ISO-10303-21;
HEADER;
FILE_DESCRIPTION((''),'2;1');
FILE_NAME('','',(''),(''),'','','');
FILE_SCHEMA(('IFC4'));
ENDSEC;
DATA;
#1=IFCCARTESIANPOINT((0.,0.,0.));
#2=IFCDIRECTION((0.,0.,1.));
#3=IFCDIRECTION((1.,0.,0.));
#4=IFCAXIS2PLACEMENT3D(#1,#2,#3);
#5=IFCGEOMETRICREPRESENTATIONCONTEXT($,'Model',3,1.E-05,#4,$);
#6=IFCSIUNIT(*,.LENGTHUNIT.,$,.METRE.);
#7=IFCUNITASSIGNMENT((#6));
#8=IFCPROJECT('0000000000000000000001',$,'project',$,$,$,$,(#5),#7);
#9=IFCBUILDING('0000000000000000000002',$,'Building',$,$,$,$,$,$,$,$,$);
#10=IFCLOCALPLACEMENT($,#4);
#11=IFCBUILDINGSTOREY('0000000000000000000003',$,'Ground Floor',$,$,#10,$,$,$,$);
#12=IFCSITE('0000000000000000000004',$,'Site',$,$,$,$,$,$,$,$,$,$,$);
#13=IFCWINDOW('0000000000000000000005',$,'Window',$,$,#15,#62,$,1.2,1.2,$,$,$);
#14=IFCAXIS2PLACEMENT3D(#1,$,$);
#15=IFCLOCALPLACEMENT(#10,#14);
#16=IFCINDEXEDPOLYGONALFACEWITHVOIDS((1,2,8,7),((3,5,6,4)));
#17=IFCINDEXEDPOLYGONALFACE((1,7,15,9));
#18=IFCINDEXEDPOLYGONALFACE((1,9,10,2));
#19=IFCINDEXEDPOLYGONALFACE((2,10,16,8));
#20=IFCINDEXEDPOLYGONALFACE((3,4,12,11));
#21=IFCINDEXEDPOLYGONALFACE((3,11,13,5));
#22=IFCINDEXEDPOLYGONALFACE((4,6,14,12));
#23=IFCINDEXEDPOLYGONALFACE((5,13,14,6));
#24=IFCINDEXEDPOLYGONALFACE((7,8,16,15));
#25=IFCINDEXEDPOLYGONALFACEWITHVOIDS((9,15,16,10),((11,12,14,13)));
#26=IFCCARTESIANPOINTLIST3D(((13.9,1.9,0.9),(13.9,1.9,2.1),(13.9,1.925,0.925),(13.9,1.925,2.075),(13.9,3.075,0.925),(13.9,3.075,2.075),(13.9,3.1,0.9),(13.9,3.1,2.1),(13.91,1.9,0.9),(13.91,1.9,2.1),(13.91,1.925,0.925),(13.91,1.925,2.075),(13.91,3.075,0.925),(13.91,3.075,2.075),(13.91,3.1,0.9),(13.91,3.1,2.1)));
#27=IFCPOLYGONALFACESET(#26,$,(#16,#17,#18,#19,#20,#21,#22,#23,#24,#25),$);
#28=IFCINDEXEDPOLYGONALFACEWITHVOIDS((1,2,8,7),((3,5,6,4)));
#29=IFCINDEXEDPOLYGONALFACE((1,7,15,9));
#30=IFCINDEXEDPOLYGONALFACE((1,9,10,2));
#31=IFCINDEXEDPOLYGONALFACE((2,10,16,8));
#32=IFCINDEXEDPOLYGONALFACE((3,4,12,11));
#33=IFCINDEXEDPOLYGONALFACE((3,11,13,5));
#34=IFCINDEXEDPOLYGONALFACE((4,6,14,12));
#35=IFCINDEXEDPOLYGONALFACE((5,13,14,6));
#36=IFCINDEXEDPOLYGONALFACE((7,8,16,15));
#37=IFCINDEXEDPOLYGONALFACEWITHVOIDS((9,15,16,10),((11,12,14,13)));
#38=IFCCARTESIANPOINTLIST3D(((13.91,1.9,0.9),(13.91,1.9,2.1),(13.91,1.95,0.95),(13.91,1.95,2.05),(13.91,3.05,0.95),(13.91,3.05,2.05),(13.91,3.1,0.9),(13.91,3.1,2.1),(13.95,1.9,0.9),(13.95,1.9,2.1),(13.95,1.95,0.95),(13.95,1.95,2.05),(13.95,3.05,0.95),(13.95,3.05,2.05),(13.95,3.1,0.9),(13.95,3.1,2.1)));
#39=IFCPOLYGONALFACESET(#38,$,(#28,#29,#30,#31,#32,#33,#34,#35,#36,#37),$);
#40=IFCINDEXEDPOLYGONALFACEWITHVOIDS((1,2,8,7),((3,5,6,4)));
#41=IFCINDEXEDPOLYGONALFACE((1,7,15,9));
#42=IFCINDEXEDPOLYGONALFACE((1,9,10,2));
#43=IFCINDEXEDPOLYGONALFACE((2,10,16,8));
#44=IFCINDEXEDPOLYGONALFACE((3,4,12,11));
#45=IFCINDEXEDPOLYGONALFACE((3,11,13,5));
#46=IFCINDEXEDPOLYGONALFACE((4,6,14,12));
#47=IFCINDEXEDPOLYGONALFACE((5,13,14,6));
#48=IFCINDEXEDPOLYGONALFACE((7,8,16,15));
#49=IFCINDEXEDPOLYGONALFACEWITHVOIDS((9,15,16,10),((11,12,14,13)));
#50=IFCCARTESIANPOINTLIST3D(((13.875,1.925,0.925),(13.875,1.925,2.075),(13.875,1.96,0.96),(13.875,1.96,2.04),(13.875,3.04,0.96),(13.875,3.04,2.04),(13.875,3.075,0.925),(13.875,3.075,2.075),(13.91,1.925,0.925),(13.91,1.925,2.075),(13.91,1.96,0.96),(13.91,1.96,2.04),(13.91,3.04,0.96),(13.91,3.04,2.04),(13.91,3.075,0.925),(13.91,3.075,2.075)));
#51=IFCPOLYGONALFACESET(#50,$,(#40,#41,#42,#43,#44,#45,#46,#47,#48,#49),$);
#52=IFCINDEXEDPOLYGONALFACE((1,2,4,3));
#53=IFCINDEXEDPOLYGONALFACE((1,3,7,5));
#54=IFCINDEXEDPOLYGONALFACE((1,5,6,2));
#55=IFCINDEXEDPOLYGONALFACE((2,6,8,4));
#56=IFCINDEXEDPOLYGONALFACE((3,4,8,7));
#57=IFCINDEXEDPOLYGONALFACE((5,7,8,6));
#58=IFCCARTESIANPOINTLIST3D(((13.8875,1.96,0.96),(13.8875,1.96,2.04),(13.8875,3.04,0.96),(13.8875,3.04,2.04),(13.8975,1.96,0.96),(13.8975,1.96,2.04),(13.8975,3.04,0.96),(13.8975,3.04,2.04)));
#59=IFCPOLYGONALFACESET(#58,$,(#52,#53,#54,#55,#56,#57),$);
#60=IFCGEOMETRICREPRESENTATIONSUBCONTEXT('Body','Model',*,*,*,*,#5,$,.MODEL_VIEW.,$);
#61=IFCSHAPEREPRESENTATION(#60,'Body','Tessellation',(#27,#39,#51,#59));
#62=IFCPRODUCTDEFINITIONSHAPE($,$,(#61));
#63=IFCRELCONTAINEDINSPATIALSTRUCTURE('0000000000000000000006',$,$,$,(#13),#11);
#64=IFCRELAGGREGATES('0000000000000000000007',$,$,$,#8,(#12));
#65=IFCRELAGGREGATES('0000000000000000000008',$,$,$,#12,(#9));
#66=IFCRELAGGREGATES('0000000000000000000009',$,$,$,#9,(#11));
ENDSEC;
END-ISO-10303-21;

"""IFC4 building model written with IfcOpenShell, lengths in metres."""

from ifc_helpers import new_model, si_unit, frame, origin_with_axes, place, context, subcontext, project, spatial, line, indexed_curve, outline, extrude, element, save


model = new_model("IFC4")

# Units and contexts
model_context = context("Model", 3, precision=1e-05, world=origin_with_axes())
body_context = subcontext(model_context, "Body", "Model", "MODEL_VIEW")
ifc_project = project(units=[si_unit("LENGTHUNIT", "METRE")], contexts=[model_context])

# Site, building, storey
site = spatial("IfcSite", under=ifc_project, Name="Site")
building = spatial("IfcBuilding", under=site, Name="Building")
storey_placement = place(None, origin_with_axes())
storey = spatial("IfcBuildingStorey", under=building, at=storey_placement, Name="Ground Floor")

# Window
window_1_placement = place(storey_placement, frame((14.0, 1.9, 0.9), z_axis=(0.0, 0.0, 1.0), x_axis=(0.0, 1.0, 0.0)))
element("IfcWindow", 1, at=window_1_placement, inside=storey, Name="Window", OverallHeight=1.2, OverallWidth=1.2, context=body_context, shape_type="SweptSolid", body=[
    extrude(outline(indexed_curve([(0.0, 0.0), (1.2, 0.0), (1.2, 1.2), (0.0, 1.2)], segments=[line(1, 2, 3, 4, 1)]), holes=[indexed_curve([(0.025, 0.025), (1.175, 0.025), (1.175, 1.175), (0.025, 1.175)], segments=[line(1, 2, 3, 4, 1)])]), frame((0.0, 0.09, 0.0), z_axis=(0.0, -1.0, 0.0), x_axis=(1.0, 0.0, 0.0)), (0.0, 0.0, -1.0), 0.01),
    extrude(outline(indexed_curve([(0.0, 0.0), (1.2, 0.0), (1.2, 1.2), (0.0, 1.2)], segments=[line(1, 2, 3, 4, 1)]), holes=[indexed_curve([(0.05, 0.05), (1.15, 0.05), (1.15, 1.15), (0.05, 1.15)], segments=[line(1, 2, 3, 4, 1)])]), frame((0.0, 0.05, 0.0), z_axis=(0.0, -1.0, 0.0), x_axis=(1.0, 0.0, 0.0)), (0.0, 0.0, -1.0), 0.04),
    extrude(outline(indexed_curve([(0.0, 0.0), (1.15, 0.0), (1.15, 1.15), (0.0, 1.15)], segments=[line(1, 2, 3, 4, 1)]), holes=[indexed_curve([(0.035, 0.035), (1.115, 0.035), (1.115, 1.115), (0.035, 1.115)], segments=[line(1, 2, 3, 4, 1)])]), frame((0.025, 0.09, 0.025), z_axis=(0.0, -1.0, 0.0), x_axis=(1.0, 0.0, 0.0)), (0.0, 0.0, -1.0), 0.035),
    extrude(outline(indexed_curve([(0.035, 0.035), (1.115, 0.035), (1.115, 1.115), (0.035, 1.115)], segments=[line(1, 2, 3, 4, 1)])), frame((0.025, 0.1025, 0.025), z_axis=(0.0, -1.0, 0.0), x_axis=(1.0, 0.0, 0.0)), (0.0, 0.0, -1.0), 0.01),
])

save(model, "model.ifc")
